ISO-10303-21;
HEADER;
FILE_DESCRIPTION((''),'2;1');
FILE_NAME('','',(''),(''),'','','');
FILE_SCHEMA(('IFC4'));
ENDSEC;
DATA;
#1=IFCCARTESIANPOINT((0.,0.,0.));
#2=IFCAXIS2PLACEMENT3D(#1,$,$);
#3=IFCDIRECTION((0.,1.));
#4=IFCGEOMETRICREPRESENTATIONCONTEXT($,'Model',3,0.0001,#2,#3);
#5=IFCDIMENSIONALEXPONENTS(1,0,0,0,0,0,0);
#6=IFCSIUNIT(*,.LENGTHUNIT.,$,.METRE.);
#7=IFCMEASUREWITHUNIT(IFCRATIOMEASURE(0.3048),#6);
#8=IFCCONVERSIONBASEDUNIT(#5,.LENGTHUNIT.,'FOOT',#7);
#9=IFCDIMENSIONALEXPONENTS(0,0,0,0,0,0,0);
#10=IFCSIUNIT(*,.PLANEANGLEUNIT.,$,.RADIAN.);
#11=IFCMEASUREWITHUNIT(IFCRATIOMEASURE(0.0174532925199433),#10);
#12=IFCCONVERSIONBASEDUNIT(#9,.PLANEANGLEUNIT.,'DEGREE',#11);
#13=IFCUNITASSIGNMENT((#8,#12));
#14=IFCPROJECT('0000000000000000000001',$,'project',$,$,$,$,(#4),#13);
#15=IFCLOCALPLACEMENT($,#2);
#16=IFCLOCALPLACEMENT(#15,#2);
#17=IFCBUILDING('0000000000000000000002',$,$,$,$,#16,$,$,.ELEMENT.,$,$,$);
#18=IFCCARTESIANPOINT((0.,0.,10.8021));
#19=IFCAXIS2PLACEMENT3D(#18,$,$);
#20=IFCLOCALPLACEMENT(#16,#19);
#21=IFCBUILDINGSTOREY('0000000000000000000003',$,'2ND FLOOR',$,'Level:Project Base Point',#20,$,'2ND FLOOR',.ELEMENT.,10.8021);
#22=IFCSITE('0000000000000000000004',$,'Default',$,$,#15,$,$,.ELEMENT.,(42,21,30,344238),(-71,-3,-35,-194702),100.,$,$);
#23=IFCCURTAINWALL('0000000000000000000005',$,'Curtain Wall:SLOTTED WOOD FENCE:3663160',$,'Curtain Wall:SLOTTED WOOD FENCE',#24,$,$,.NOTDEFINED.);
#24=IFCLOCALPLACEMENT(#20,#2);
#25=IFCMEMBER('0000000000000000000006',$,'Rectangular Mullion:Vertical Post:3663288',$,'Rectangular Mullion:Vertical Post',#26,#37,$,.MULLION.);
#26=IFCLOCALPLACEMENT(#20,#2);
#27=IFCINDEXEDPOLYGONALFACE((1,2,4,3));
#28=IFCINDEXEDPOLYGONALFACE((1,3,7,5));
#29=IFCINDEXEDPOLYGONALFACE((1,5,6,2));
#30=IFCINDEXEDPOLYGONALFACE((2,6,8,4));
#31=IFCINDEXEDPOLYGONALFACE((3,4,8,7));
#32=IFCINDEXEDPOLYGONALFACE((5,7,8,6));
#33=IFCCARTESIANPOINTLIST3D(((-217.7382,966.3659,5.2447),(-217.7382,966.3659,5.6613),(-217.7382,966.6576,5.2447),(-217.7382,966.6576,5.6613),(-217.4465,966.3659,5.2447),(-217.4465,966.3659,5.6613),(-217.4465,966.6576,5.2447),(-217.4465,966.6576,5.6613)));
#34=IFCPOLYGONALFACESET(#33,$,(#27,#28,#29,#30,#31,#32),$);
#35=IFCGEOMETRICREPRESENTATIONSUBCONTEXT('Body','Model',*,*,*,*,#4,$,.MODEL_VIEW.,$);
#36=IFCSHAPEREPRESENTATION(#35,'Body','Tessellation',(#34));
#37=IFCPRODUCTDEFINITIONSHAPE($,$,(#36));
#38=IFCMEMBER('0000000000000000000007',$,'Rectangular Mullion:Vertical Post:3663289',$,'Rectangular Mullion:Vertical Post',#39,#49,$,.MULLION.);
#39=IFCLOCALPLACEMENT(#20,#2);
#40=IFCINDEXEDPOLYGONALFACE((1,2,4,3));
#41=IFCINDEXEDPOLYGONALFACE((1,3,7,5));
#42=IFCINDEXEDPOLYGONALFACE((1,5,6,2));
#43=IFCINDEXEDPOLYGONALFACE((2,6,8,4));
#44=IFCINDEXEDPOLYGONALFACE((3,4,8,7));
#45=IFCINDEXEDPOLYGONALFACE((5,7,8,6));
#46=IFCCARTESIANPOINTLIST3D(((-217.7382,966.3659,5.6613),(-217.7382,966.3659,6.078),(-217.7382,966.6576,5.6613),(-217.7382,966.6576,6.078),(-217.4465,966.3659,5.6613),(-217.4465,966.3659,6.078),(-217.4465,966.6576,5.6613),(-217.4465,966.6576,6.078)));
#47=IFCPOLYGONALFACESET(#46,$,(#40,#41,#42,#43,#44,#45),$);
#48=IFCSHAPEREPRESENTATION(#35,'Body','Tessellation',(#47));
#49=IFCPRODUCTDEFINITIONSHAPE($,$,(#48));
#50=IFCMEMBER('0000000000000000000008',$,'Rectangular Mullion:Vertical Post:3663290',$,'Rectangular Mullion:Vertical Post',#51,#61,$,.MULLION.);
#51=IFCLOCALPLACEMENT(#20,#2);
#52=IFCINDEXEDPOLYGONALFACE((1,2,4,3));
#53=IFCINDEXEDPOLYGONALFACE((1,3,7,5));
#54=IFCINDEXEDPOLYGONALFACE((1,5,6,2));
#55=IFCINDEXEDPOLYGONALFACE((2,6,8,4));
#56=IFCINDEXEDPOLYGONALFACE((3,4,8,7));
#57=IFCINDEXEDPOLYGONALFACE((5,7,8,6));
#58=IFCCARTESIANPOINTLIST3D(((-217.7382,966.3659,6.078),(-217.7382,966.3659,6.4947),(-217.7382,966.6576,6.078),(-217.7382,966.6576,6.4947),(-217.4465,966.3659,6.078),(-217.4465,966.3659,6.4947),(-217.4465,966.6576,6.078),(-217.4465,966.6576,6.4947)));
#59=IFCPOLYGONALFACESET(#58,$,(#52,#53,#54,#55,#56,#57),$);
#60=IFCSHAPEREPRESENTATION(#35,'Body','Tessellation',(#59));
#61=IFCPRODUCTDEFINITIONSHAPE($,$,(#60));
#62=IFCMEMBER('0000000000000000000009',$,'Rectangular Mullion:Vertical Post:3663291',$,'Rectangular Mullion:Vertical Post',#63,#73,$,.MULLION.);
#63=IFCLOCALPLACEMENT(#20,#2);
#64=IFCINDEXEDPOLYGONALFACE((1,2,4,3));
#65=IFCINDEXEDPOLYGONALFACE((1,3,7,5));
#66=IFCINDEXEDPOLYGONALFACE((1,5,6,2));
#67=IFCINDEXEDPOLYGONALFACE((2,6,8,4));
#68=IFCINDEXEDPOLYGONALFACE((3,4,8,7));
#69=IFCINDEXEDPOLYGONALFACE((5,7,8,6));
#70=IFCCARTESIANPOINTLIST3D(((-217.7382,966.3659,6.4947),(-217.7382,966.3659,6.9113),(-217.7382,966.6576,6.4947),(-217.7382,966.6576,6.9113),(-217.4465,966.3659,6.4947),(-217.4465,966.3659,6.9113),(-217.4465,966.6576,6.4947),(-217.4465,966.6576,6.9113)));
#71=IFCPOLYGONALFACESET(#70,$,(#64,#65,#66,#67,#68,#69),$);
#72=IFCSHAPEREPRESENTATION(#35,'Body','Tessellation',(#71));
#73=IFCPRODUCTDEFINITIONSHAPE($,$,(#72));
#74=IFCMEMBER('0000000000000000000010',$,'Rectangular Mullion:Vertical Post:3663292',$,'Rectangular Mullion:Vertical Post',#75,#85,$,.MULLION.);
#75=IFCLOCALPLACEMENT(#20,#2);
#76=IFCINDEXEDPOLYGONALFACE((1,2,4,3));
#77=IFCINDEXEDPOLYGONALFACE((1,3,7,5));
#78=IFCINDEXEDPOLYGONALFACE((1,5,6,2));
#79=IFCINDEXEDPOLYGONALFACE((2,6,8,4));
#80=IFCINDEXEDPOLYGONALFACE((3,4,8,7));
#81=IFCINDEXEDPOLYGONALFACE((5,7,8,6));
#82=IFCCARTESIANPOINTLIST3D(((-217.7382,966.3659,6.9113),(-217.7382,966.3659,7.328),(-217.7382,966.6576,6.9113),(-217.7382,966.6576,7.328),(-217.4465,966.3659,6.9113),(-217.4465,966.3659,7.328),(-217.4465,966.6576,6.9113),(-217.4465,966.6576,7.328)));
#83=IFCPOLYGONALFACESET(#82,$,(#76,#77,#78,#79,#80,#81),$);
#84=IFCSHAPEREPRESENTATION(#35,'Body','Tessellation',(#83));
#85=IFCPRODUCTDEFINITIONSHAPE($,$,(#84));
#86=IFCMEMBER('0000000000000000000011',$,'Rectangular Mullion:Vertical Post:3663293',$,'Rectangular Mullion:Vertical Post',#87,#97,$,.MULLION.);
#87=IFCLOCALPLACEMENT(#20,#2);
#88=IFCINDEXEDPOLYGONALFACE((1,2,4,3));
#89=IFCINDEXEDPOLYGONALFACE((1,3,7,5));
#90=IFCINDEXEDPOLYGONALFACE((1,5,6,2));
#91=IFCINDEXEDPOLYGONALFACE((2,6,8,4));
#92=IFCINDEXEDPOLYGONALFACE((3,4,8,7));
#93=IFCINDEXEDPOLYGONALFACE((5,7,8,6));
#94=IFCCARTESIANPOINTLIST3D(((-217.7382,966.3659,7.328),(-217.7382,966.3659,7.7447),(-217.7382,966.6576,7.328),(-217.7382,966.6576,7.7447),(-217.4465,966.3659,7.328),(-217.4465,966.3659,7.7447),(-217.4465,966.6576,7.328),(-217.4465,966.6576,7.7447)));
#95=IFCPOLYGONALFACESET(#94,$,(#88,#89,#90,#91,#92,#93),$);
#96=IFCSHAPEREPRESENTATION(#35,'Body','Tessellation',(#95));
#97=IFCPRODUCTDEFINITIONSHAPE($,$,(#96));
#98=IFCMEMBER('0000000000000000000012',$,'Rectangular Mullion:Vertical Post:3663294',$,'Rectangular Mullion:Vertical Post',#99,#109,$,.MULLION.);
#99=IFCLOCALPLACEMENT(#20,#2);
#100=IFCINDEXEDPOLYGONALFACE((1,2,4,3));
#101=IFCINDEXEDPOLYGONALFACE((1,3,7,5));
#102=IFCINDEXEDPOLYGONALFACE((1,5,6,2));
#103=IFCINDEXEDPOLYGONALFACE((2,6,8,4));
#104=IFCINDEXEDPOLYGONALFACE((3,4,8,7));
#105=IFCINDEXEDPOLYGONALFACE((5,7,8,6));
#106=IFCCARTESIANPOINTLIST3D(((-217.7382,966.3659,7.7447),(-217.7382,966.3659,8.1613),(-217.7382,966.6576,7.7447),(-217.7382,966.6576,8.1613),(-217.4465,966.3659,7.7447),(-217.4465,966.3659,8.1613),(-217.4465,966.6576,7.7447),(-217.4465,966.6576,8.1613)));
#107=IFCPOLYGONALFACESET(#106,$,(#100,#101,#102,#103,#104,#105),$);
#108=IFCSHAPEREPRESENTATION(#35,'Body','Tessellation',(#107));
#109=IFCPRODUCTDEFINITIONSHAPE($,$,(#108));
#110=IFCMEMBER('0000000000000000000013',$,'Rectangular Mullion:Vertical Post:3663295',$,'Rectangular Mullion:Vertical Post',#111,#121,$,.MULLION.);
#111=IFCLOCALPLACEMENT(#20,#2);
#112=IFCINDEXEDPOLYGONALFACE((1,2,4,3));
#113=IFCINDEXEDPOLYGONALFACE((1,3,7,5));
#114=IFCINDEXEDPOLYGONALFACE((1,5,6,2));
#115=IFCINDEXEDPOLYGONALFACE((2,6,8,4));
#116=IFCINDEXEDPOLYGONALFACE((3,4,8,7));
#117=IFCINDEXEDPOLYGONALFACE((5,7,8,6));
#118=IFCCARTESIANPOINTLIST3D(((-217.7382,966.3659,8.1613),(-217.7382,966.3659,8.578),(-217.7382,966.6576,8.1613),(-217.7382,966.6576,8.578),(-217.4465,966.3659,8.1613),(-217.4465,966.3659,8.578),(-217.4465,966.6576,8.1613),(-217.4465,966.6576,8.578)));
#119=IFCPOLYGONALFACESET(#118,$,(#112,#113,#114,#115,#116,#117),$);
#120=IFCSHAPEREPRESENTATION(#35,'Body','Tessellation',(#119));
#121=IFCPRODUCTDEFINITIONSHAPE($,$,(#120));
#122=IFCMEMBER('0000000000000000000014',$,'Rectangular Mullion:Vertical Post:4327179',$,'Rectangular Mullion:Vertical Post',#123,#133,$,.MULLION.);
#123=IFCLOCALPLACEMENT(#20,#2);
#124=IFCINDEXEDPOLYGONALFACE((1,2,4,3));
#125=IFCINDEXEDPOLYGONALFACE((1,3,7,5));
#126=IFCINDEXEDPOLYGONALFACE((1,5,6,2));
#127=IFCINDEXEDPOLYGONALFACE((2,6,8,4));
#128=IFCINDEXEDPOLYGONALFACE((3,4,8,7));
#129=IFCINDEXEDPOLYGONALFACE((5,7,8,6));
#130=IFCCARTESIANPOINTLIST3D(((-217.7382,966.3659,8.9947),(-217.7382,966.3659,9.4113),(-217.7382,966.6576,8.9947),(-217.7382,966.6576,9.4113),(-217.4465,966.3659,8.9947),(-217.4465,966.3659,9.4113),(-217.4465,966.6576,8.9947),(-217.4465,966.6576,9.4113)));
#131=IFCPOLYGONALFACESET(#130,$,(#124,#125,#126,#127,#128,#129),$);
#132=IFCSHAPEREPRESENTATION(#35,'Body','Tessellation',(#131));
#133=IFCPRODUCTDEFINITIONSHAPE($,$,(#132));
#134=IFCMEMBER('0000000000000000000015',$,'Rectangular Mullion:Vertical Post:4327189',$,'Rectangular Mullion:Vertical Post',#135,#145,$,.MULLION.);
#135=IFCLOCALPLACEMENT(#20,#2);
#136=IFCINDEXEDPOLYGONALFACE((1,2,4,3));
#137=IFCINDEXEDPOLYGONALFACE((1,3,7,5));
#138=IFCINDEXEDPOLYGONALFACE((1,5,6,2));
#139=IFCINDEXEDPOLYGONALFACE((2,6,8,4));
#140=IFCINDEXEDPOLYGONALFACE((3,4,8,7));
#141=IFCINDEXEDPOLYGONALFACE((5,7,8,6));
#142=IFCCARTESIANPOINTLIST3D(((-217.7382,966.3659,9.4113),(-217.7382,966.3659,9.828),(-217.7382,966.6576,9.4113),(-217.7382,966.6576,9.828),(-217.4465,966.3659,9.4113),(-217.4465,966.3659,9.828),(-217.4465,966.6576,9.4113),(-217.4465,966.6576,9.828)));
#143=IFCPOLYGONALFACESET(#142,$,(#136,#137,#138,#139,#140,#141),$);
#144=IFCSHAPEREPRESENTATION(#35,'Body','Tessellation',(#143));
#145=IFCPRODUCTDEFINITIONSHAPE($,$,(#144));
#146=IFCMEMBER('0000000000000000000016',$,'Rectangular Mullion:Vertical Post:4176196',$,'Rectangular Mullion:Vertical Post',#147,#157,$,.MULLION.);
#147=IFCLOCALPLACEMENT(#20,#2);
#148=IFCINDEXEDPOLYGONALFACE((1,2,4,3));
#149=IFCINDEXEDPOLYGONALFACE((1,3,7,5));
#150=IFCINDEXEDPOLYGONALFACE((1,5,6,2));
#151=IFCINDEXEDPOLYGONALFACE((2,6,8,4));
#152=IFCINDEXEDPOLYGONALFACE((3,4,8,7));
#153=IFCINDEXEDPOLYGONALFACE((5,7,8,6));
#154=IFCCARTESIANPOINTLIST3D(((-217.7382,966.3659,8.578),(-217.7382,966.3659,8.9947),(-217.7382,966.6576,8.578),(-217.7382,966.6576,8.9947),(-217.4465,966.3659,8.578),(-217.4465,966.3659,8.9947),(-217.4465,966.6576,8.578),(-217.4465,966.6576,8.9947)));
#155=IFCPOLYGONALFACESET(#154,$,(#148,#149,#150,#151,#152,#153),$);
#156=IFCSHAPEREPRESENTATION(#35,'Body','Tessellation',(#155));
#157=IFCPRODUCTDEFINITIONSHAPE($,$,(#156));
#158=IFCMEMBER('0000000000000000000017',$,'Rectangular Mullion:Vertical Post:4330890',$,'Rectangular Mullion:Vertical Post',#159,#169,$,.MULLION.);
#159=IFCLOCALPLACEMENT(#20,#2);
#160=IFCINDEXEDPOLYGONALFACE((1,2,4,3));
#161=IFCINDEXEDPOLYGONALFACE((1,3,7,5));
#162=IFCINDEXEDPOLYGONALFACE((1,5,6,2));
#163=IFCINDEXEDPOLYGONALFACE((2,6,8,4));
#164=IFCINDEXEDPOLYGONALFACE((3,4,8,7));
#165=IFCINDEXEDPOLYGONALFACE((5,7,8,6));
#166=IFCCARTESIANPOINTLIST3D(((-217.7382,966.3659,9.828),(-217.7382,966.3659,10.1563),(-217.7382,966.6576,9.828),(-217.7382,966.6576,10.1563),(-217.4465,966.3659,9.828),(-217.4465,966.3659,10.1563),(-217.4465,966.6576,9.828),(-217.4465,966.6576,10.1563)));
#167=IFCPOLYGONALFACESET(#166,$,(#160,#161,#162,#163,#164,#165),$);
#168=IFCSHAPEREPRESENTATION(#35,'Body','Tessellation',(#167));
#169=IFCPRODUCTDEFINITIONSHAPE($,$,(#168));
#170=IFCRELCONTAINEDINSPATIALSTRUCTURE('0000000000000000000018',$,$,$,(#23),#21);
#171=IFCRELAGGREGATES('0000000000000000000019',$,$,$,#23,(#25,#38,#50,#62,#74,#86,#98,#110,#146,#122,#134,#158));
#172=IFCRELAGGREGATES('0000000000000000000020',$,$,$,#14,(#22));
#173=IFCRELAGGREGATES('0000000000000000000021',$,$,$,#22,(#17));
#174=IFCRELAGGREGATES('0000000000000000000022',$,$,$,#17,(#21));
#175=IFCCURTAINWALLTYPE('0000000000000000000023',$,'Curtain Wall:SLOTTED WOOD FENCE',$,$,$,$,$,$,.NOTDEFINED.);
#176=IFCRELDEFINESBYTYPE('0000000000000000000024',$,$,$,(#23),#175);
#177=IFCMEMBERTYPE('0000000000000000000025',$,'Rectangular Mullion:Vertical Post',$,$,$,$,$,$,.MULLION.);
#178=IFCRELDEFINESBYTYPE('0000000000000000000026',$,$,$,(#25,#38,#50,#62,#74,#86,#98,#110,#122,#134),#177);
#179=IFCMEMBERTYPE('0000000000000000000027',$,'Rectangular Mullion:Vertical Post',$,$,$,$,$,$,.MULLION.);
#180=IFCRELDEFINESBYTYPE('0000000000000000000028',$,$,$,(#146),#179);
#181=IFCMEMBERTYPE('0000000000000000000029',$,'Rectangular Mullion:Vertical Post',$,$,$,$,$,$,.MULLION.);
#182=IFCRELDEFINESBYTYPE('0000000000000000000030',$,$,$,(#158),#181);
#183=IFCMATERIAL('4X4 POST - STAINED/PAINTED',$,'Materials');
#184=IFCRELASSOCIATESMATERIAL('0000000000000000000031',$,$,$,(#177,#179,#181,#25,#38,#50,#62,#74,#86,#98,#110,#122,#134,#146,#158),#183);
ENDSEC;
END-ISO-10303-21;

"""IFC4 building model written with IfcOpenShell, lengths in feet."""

from ifc_helpers import new_model, entity, si_unit, converted_unit, direction, frame, origin, origin_2d_with_axis, place, context, subcontext, project, spatial, rectangle, extrude, source, transform, mapped, material, material_profile, profile_set, profile_usage, type_object, type_shapes, element, aggregate, save


model = new_model("IFC4")

# Units and contexts
model_context = context("Model", 3, precision=0.0001, world=origin(), true_north=direction((0.0, 1.0)))
body_context = subcontext(model_context, "Body", "Model", "MODEL_VIEW")
ifc_project = project(units=[converted_unit("LENGTHUNIT", "FOOT", entity("IfcRatioMeasure", 0.3048), si_unit("LENGTHUNIT", "METRE"), dimensions=[1, 0, 0, 0, 0, 0, 0]), converted_unit("PLANEANGLEUNIT", "DEGREE", entity("IfcRatioMeasure", 0.0174532925199433), si_unit("PLANEANGLEUNIT", "RADIAN"), dimensions=[0, 0, 0, 0, 0, 0, 0])], contexts=[model_context])

# Site, building, storey
site_placement = place(None, origin())
site = spatial("IfcSite", under=ifc_project, at=site_placement, Name="Default", CompositionType="ELEMENT", RefLatitude=(42, 21, 30, 344238), RefLongitude=(-71, -3, -35, -194702), RefElevation=100.0)
building_placement = place(site_placement, origin())
building = spatial("IfcBuilding", under=site, at=building_placement, CompositionType="ELEMENT")
storey_placement = place(building_placement, frame((0.0, 0.0, 10.8021)))
storey = spatial("IfcBuildingStorey", under=building, at=storey_placement, Name="2ND FLOOR", ObjectType="Level:Project Base Point", LongName="2ND FLOOR", CompositionType="ELEMENT", Elevation=10.8021)

# Curtain wall, members
curtain_wall_type = type_object("IfcCurtainWallType", Name="Curtain Wall:SLOTTED WOOD FENCE", PredefinedType="NOTDEFINED")
curtain_wall_placement = place(storey_placement, frame((0.0, 0.0, -10.8021)))
curtain_wall = element("IfcCurtainWall", 1, at=curtain_wall_placement, inside=storey, type_object=curtain_wall_type, Name="Curtain Wall:SLOTTED WOOD FENCE:3663160", ObjectType="Curtain Wall:SLOTTED WOOD FENCE", PredefinedType="NOTDEFINED")
ifc_material_1 = material(Name="4X4 POST - STAINED/PAINTED", Category="Materials")
ifc_material_profile = material_profile(ifc_material_1, rectangle(XDim=0.2917, YDim=0.2917, at=origin_2d_with_axis()), Name="Vertical Post")
ifc_profile_set = profile_set([ifc_material_profile], Name="Vertical Post")
member_type_1 = type_object("IfcMemberType", Name="Rectangular Mullion:Vertical Post", PredefinedType="MULLION", material=ifc_profile_set)
shared_shape_1 = source(origin(), body_context, "Body", "SweptSolid", [
    extrude(rectangle(XDim=0.2917, YDim=0.2917, at=origin_2d_with_axis()), frame((0.0, -0.2083, -0.4167), z_axis=(0.0, 0.0, 1.0), x_axis=(0.0, -1.0, 0.0)), (0.0, 0.0, 1.0), 0.4167),
])
type_shapes(member_type_1, [shared_shape_1])
ifc_profile_usage_1 = profile_usage(ifc_profile_set)
member_1_placement = place(storey_placement, frame((-217.8007, 966.5118, 5.2447), z_axis=(0.0, 0.0, -1.0), x_axis=(0.0, -1.0, 0.0)))
member_1 = element("IfcMember", 2, at=member_1_placement, type_object=member_type_1, material=ifc_profile_usage_1, Name="Rectangular Mullion:Vertical Post:3663288", ObjectType="Rectangular Mullion:Vertical Post", PredefinedType="MULLION", context=body_context, shape_type="MappedRepresentation", body=[
    mapped(shared_shape_1, transform((0.0, 0.0, 0.0), scale=1.0)),
])
ifc_profile_usage_2 = profile_usage(ifc_profile_set)
member_2_placement = place(storey_placement, frame((-217.8007, 966.5118, 5.6613), z_axis=(0.0, 0.0, -1.0), x_axis=(0.0, -1.0, 0.0)))
member_2 = element("IfcMember", 3, at=member_2_placement, type_object=member_type_1, material=ifc_profile_usage_2, Name="Rectangular Mullion:Vertical Post:3663289", ObjectType="Rectangular Mullion:Vertical Post", PredefinedType="MULLION", context=body_context, shape_type="MappedRepresentation", body=[
    mapped(shared_shape_1, transform((0.0, 0.0, 0.0), scale=1.0)),
])
ifc_profile_usage_3 = profile_usage(ifc_profile_set)
member_3_placement = place(storey_placement, frame((-217.8007, 966.5118, 6.078), z_axis=(0.0, 0.0, -1.0), x_axis=(0.0, -1.0, 0.0)))
member_3 = element("IfcMember", 4, at=member_3_placement, type_object=member_type_1, material=ifc_profile_usage_3, Name="Rectangular Mullion:Vertical Post:3663290", ObjectType="Rectangular Mullion:Vertical Post", PredefinedType="MULLION", context=body_context, shape_type="MappedRepresentation", body=[
    mapped(shared_shape_1, transform((0.0, 0.0, 0.0), scale=1.0)),
])
ifc_profile_usage_4 = profile_usage(ifc_profile_set)
member_4_placement = place(storey_placement, frame((-217.8007, 966.5118, 6.4947), z_axis=(0.0, 0.0, -1.0), x_axis=(0.0, -1.0, 0.0)))
member_4 = element("IfcMember", 5, at=member_4_placement, type_object=member_type_1, material=ifc_profile_usage_4, Name="Rectangular Mullion:Vertical Post:3663291", ObjectType="Rectangular Mullion:Vertical Post", PredefinedType="MULLION", context=body_context, shape_type="MappedRepresentation", body=[
    mapped(shared_shape_1, transform((0.0, 0.0, 0.0), scale=1.0)),
])
ifc_profile_usage_5 = profile_usage(ifc_profile_set)
member_5_placement = place(storey_placement, frame((-217.8007, 966.5118, 6.9113), z_axis=(0.0, 0.0, -1.0), x_axis=(0.0, -1.0, 0.0)))
member_5 = element("IfcMember", 6, at=member_5_placement, type_object=member_type_1, material=ifc_profile_usage_5, Name="Rectangular Mullion:Vertical Post:3663292", ObjectType="Rectangular Mullion:Vertical Post", PredefinedType="MULLION", context=body_context, shape_type="MappedRepresentation", body=[
    mapped(shared_shape_1, transform((0.0, 0.0, 0.0), scale=1.0)),
])
ifc_profile_usage_6 = profile_usage(ifc_profile_set)
member_6_placement = place(storey_placement, frame((-217.8007, 966.5118, 7.328), z_axis=(0.0, 0.0, -1.0), x_axis=(0.0, -1.0, 0.0)))
member_6 = element("IfcMember", 7, at=member_6_placement, type_object=member_type_1, material=ifc_profile_usage_6, Name="Rectangular Mullion:Vertical Post:3663293", ObjectType="Rectangular Mullion:Vertical Post", PredefinedType="MULLION", context=body_context, shape_type="MappedRepresentation", body=[
    mapped(shared_shape_1, transform((0.0, 0.0, 0.0), scale=1.0)),
])
ifc_profile_usage_7 = profile_usage(ifc_profile_set)
member_7_placement = place(storey_placement, frame((-217.8007, 966.5118, 7.7447), z_axis=(0.0, 0.0, -1.0), x_axis=(0.0, -1.0, 0.0)))
member_7 = element("IfcMember", 8, at=member_7_placement, type_object=member_type_1, material=ifc_profile_usage_7, Name="Rectangular Mullion:Vertical Post:3663294", ObjectType="Rectangular Mullion:Vertical Post", PredefinedType="MULLION", context=body_context, shape_type="MappedRepresentation", body=[
    mapped(shared_shape_1, transform((0.0, 0.0, 0.0), scale=1.0)),
])
ifc_profile_usage_8 = profile_usage(ifc_profile_set)
member_8_placement = place(storey_placement, frame((-217.8007, 966.5118, 8.1613), z_axis=(0.0, 0.0, -1.0), x_axis=(0.0, -1.0, 0.0)))
member_8 = element("IfcMember", 9, at=member_8_placement, type_object=member_type_1, material=ifc_profile_usage_8, Name="Rectangular Mullion:Vertical Post:3663295", ObjectType="Rectangular Mullion:Vertical Post", PredefinedType="MULLION", context=body_context, shape_type="MappedRepresentation", body=[
    mapped(shared_shape_1, transform((0.0, 0.0, 0.0), scale=1.0)),
])
ifc_profile_usage_9 = profile_usage(ifc_profile_set)
member_9_placement = place(storey_placement, frame((-217.8007, 966.5118, 8.9947), z_axis=(0.0, 0.0, -1.0), x_axis=(0.0, -1.0, 0.0)))
member_9 = element("IfcMember", 10, at=member_9_placement, type_object=member_type_1, material=ifc_profile_usage_9, Name="Rectangular Mullion:Vertical Post:4327179", ObjectType="Rectangular Mullion:Vertical Post", PredefinedType="MULLION", context=body_context, shape_type="MappedRepresentation", body=[
    mapped(shared_shape_1, transform((0.0, 0.0, 0.0), scale=1.0)),
])
ifc_profile_usage_10 = profile_usage(ifc_profile_set)
member_10_placement = place(storey_placement, frame((-217.8007, 966.5118, 9.4113), z_axis=(0.0, 0.0, -1.0), x_axis=(0.0, -1.0, 0.0)))
member_10 = element("IfcMember", 11, at=member_10_placement, type_object=member_type_1, material=ifc_profile_usage_10, Name="Rectangular Mullion:Vertical Post:4327189", ObjectType="Rectangular Mullion:Vertical Post", PredefinedType="MULLION", context=body_context, shape_type="MappedRepresentation", body=[
    mapped(shared_shape_1, transform((0.0, 0.0, 0.0), scale=1.0)),
])
ifc_profile_usage_11 = profile_usage(ifc_profile_set)
member_type_2 = type_object("IfcMemberType", Name="Rectangular Mullion:Vertical Post", PredefinedType="MULLION", material=ifc_profile_set)
shared_shape_2 = source(origin(), body_context, "Body", "SweptSolid", [
    extrude(rectangle(XDim=0.2917, YDim=0.2917, at=origin_2d_with_axis()), frame((0.0, -0.2083, -0.4167), z_axis=(0.0, 0.0, 1.0), x_axis=(0.0, -1.0, 0.0)), (0.0, 0.0, 1.0), 0.4167),
])
type_shapes(member_type_2, [shared_shape_2])
member_11_placement = place(storey_placement, frame((-217.8007, 966.5118, 8.578), z_axis=(0.0, 0.0, -1.0), x_axis=(0.0, -1.0, 0.0)))
member_11 = element("IfcMember", 12, at=member_11_placement, type_object=member_type_2, material=ifc_profile_usage_11, Name="Rectangular Mullion:Vertical Post:4176196", ObjectType="Rectangular Mullion:Vertical Post", PredefinedType="MULLION", context=body_context, shape_type="MappedRepresentation", body=[
    mapped(shared_shape_2, transform((0.0, 0.0, 0.0), scale=1.0)),
])
ifc_profile_usage_12 = profile_usage(ifc_profile_set)
member_type_3 = type_object("IfcMemberType", Name="Rectangular Mullion:Vertical Post", PredefinedType="MULLION", material=ifc_profile_set)
shared_shape_3 = source(origin(), body_context, "Body", "SweptSolid", [
    extrude(rectangle(XDim=0.2917, YDim=0.2917, at=origin_2d_with_axis()), frame((0.0, -0.2083, -0.3282), z_axis=(0.0, 0.0, 1.0), x_axis=(0.0, -1.0, 0.0)), (0.0, 0.0, 1.0), 0.3282),
])
type_shapes(member_type_3, [shared_shape_3])
member_12_placement = place(storey_placement, frame((-217.8007, 966.5118, 9.828), z_axis=(0.0, 0.0, -1.0), x_axis=(0.0, -1.0, 0.0)))
member_12 = element("IfcMember", 13, at=member_12_placement, type_object=member_type_3, material=ifc_profile_usage_12, Name="Rectangular Mullion:Vertical Post:4330890", ObjectType="Rectangular Mullion:Vertical Post", PredefinedType="MULLION", context=body_context, shape_type="MappedRepresentation", body=[
    mapped(shared_shape_3, transform((0.0, 0.0, 0.0), scale=1.0)),
])
aggregate(curtain_wall, [member_1, member_2, member_3, member_4, member_5, member_6, member_7, member_8, member_11, member_9, member_10, member_12])

save(model, "model.ifc")
